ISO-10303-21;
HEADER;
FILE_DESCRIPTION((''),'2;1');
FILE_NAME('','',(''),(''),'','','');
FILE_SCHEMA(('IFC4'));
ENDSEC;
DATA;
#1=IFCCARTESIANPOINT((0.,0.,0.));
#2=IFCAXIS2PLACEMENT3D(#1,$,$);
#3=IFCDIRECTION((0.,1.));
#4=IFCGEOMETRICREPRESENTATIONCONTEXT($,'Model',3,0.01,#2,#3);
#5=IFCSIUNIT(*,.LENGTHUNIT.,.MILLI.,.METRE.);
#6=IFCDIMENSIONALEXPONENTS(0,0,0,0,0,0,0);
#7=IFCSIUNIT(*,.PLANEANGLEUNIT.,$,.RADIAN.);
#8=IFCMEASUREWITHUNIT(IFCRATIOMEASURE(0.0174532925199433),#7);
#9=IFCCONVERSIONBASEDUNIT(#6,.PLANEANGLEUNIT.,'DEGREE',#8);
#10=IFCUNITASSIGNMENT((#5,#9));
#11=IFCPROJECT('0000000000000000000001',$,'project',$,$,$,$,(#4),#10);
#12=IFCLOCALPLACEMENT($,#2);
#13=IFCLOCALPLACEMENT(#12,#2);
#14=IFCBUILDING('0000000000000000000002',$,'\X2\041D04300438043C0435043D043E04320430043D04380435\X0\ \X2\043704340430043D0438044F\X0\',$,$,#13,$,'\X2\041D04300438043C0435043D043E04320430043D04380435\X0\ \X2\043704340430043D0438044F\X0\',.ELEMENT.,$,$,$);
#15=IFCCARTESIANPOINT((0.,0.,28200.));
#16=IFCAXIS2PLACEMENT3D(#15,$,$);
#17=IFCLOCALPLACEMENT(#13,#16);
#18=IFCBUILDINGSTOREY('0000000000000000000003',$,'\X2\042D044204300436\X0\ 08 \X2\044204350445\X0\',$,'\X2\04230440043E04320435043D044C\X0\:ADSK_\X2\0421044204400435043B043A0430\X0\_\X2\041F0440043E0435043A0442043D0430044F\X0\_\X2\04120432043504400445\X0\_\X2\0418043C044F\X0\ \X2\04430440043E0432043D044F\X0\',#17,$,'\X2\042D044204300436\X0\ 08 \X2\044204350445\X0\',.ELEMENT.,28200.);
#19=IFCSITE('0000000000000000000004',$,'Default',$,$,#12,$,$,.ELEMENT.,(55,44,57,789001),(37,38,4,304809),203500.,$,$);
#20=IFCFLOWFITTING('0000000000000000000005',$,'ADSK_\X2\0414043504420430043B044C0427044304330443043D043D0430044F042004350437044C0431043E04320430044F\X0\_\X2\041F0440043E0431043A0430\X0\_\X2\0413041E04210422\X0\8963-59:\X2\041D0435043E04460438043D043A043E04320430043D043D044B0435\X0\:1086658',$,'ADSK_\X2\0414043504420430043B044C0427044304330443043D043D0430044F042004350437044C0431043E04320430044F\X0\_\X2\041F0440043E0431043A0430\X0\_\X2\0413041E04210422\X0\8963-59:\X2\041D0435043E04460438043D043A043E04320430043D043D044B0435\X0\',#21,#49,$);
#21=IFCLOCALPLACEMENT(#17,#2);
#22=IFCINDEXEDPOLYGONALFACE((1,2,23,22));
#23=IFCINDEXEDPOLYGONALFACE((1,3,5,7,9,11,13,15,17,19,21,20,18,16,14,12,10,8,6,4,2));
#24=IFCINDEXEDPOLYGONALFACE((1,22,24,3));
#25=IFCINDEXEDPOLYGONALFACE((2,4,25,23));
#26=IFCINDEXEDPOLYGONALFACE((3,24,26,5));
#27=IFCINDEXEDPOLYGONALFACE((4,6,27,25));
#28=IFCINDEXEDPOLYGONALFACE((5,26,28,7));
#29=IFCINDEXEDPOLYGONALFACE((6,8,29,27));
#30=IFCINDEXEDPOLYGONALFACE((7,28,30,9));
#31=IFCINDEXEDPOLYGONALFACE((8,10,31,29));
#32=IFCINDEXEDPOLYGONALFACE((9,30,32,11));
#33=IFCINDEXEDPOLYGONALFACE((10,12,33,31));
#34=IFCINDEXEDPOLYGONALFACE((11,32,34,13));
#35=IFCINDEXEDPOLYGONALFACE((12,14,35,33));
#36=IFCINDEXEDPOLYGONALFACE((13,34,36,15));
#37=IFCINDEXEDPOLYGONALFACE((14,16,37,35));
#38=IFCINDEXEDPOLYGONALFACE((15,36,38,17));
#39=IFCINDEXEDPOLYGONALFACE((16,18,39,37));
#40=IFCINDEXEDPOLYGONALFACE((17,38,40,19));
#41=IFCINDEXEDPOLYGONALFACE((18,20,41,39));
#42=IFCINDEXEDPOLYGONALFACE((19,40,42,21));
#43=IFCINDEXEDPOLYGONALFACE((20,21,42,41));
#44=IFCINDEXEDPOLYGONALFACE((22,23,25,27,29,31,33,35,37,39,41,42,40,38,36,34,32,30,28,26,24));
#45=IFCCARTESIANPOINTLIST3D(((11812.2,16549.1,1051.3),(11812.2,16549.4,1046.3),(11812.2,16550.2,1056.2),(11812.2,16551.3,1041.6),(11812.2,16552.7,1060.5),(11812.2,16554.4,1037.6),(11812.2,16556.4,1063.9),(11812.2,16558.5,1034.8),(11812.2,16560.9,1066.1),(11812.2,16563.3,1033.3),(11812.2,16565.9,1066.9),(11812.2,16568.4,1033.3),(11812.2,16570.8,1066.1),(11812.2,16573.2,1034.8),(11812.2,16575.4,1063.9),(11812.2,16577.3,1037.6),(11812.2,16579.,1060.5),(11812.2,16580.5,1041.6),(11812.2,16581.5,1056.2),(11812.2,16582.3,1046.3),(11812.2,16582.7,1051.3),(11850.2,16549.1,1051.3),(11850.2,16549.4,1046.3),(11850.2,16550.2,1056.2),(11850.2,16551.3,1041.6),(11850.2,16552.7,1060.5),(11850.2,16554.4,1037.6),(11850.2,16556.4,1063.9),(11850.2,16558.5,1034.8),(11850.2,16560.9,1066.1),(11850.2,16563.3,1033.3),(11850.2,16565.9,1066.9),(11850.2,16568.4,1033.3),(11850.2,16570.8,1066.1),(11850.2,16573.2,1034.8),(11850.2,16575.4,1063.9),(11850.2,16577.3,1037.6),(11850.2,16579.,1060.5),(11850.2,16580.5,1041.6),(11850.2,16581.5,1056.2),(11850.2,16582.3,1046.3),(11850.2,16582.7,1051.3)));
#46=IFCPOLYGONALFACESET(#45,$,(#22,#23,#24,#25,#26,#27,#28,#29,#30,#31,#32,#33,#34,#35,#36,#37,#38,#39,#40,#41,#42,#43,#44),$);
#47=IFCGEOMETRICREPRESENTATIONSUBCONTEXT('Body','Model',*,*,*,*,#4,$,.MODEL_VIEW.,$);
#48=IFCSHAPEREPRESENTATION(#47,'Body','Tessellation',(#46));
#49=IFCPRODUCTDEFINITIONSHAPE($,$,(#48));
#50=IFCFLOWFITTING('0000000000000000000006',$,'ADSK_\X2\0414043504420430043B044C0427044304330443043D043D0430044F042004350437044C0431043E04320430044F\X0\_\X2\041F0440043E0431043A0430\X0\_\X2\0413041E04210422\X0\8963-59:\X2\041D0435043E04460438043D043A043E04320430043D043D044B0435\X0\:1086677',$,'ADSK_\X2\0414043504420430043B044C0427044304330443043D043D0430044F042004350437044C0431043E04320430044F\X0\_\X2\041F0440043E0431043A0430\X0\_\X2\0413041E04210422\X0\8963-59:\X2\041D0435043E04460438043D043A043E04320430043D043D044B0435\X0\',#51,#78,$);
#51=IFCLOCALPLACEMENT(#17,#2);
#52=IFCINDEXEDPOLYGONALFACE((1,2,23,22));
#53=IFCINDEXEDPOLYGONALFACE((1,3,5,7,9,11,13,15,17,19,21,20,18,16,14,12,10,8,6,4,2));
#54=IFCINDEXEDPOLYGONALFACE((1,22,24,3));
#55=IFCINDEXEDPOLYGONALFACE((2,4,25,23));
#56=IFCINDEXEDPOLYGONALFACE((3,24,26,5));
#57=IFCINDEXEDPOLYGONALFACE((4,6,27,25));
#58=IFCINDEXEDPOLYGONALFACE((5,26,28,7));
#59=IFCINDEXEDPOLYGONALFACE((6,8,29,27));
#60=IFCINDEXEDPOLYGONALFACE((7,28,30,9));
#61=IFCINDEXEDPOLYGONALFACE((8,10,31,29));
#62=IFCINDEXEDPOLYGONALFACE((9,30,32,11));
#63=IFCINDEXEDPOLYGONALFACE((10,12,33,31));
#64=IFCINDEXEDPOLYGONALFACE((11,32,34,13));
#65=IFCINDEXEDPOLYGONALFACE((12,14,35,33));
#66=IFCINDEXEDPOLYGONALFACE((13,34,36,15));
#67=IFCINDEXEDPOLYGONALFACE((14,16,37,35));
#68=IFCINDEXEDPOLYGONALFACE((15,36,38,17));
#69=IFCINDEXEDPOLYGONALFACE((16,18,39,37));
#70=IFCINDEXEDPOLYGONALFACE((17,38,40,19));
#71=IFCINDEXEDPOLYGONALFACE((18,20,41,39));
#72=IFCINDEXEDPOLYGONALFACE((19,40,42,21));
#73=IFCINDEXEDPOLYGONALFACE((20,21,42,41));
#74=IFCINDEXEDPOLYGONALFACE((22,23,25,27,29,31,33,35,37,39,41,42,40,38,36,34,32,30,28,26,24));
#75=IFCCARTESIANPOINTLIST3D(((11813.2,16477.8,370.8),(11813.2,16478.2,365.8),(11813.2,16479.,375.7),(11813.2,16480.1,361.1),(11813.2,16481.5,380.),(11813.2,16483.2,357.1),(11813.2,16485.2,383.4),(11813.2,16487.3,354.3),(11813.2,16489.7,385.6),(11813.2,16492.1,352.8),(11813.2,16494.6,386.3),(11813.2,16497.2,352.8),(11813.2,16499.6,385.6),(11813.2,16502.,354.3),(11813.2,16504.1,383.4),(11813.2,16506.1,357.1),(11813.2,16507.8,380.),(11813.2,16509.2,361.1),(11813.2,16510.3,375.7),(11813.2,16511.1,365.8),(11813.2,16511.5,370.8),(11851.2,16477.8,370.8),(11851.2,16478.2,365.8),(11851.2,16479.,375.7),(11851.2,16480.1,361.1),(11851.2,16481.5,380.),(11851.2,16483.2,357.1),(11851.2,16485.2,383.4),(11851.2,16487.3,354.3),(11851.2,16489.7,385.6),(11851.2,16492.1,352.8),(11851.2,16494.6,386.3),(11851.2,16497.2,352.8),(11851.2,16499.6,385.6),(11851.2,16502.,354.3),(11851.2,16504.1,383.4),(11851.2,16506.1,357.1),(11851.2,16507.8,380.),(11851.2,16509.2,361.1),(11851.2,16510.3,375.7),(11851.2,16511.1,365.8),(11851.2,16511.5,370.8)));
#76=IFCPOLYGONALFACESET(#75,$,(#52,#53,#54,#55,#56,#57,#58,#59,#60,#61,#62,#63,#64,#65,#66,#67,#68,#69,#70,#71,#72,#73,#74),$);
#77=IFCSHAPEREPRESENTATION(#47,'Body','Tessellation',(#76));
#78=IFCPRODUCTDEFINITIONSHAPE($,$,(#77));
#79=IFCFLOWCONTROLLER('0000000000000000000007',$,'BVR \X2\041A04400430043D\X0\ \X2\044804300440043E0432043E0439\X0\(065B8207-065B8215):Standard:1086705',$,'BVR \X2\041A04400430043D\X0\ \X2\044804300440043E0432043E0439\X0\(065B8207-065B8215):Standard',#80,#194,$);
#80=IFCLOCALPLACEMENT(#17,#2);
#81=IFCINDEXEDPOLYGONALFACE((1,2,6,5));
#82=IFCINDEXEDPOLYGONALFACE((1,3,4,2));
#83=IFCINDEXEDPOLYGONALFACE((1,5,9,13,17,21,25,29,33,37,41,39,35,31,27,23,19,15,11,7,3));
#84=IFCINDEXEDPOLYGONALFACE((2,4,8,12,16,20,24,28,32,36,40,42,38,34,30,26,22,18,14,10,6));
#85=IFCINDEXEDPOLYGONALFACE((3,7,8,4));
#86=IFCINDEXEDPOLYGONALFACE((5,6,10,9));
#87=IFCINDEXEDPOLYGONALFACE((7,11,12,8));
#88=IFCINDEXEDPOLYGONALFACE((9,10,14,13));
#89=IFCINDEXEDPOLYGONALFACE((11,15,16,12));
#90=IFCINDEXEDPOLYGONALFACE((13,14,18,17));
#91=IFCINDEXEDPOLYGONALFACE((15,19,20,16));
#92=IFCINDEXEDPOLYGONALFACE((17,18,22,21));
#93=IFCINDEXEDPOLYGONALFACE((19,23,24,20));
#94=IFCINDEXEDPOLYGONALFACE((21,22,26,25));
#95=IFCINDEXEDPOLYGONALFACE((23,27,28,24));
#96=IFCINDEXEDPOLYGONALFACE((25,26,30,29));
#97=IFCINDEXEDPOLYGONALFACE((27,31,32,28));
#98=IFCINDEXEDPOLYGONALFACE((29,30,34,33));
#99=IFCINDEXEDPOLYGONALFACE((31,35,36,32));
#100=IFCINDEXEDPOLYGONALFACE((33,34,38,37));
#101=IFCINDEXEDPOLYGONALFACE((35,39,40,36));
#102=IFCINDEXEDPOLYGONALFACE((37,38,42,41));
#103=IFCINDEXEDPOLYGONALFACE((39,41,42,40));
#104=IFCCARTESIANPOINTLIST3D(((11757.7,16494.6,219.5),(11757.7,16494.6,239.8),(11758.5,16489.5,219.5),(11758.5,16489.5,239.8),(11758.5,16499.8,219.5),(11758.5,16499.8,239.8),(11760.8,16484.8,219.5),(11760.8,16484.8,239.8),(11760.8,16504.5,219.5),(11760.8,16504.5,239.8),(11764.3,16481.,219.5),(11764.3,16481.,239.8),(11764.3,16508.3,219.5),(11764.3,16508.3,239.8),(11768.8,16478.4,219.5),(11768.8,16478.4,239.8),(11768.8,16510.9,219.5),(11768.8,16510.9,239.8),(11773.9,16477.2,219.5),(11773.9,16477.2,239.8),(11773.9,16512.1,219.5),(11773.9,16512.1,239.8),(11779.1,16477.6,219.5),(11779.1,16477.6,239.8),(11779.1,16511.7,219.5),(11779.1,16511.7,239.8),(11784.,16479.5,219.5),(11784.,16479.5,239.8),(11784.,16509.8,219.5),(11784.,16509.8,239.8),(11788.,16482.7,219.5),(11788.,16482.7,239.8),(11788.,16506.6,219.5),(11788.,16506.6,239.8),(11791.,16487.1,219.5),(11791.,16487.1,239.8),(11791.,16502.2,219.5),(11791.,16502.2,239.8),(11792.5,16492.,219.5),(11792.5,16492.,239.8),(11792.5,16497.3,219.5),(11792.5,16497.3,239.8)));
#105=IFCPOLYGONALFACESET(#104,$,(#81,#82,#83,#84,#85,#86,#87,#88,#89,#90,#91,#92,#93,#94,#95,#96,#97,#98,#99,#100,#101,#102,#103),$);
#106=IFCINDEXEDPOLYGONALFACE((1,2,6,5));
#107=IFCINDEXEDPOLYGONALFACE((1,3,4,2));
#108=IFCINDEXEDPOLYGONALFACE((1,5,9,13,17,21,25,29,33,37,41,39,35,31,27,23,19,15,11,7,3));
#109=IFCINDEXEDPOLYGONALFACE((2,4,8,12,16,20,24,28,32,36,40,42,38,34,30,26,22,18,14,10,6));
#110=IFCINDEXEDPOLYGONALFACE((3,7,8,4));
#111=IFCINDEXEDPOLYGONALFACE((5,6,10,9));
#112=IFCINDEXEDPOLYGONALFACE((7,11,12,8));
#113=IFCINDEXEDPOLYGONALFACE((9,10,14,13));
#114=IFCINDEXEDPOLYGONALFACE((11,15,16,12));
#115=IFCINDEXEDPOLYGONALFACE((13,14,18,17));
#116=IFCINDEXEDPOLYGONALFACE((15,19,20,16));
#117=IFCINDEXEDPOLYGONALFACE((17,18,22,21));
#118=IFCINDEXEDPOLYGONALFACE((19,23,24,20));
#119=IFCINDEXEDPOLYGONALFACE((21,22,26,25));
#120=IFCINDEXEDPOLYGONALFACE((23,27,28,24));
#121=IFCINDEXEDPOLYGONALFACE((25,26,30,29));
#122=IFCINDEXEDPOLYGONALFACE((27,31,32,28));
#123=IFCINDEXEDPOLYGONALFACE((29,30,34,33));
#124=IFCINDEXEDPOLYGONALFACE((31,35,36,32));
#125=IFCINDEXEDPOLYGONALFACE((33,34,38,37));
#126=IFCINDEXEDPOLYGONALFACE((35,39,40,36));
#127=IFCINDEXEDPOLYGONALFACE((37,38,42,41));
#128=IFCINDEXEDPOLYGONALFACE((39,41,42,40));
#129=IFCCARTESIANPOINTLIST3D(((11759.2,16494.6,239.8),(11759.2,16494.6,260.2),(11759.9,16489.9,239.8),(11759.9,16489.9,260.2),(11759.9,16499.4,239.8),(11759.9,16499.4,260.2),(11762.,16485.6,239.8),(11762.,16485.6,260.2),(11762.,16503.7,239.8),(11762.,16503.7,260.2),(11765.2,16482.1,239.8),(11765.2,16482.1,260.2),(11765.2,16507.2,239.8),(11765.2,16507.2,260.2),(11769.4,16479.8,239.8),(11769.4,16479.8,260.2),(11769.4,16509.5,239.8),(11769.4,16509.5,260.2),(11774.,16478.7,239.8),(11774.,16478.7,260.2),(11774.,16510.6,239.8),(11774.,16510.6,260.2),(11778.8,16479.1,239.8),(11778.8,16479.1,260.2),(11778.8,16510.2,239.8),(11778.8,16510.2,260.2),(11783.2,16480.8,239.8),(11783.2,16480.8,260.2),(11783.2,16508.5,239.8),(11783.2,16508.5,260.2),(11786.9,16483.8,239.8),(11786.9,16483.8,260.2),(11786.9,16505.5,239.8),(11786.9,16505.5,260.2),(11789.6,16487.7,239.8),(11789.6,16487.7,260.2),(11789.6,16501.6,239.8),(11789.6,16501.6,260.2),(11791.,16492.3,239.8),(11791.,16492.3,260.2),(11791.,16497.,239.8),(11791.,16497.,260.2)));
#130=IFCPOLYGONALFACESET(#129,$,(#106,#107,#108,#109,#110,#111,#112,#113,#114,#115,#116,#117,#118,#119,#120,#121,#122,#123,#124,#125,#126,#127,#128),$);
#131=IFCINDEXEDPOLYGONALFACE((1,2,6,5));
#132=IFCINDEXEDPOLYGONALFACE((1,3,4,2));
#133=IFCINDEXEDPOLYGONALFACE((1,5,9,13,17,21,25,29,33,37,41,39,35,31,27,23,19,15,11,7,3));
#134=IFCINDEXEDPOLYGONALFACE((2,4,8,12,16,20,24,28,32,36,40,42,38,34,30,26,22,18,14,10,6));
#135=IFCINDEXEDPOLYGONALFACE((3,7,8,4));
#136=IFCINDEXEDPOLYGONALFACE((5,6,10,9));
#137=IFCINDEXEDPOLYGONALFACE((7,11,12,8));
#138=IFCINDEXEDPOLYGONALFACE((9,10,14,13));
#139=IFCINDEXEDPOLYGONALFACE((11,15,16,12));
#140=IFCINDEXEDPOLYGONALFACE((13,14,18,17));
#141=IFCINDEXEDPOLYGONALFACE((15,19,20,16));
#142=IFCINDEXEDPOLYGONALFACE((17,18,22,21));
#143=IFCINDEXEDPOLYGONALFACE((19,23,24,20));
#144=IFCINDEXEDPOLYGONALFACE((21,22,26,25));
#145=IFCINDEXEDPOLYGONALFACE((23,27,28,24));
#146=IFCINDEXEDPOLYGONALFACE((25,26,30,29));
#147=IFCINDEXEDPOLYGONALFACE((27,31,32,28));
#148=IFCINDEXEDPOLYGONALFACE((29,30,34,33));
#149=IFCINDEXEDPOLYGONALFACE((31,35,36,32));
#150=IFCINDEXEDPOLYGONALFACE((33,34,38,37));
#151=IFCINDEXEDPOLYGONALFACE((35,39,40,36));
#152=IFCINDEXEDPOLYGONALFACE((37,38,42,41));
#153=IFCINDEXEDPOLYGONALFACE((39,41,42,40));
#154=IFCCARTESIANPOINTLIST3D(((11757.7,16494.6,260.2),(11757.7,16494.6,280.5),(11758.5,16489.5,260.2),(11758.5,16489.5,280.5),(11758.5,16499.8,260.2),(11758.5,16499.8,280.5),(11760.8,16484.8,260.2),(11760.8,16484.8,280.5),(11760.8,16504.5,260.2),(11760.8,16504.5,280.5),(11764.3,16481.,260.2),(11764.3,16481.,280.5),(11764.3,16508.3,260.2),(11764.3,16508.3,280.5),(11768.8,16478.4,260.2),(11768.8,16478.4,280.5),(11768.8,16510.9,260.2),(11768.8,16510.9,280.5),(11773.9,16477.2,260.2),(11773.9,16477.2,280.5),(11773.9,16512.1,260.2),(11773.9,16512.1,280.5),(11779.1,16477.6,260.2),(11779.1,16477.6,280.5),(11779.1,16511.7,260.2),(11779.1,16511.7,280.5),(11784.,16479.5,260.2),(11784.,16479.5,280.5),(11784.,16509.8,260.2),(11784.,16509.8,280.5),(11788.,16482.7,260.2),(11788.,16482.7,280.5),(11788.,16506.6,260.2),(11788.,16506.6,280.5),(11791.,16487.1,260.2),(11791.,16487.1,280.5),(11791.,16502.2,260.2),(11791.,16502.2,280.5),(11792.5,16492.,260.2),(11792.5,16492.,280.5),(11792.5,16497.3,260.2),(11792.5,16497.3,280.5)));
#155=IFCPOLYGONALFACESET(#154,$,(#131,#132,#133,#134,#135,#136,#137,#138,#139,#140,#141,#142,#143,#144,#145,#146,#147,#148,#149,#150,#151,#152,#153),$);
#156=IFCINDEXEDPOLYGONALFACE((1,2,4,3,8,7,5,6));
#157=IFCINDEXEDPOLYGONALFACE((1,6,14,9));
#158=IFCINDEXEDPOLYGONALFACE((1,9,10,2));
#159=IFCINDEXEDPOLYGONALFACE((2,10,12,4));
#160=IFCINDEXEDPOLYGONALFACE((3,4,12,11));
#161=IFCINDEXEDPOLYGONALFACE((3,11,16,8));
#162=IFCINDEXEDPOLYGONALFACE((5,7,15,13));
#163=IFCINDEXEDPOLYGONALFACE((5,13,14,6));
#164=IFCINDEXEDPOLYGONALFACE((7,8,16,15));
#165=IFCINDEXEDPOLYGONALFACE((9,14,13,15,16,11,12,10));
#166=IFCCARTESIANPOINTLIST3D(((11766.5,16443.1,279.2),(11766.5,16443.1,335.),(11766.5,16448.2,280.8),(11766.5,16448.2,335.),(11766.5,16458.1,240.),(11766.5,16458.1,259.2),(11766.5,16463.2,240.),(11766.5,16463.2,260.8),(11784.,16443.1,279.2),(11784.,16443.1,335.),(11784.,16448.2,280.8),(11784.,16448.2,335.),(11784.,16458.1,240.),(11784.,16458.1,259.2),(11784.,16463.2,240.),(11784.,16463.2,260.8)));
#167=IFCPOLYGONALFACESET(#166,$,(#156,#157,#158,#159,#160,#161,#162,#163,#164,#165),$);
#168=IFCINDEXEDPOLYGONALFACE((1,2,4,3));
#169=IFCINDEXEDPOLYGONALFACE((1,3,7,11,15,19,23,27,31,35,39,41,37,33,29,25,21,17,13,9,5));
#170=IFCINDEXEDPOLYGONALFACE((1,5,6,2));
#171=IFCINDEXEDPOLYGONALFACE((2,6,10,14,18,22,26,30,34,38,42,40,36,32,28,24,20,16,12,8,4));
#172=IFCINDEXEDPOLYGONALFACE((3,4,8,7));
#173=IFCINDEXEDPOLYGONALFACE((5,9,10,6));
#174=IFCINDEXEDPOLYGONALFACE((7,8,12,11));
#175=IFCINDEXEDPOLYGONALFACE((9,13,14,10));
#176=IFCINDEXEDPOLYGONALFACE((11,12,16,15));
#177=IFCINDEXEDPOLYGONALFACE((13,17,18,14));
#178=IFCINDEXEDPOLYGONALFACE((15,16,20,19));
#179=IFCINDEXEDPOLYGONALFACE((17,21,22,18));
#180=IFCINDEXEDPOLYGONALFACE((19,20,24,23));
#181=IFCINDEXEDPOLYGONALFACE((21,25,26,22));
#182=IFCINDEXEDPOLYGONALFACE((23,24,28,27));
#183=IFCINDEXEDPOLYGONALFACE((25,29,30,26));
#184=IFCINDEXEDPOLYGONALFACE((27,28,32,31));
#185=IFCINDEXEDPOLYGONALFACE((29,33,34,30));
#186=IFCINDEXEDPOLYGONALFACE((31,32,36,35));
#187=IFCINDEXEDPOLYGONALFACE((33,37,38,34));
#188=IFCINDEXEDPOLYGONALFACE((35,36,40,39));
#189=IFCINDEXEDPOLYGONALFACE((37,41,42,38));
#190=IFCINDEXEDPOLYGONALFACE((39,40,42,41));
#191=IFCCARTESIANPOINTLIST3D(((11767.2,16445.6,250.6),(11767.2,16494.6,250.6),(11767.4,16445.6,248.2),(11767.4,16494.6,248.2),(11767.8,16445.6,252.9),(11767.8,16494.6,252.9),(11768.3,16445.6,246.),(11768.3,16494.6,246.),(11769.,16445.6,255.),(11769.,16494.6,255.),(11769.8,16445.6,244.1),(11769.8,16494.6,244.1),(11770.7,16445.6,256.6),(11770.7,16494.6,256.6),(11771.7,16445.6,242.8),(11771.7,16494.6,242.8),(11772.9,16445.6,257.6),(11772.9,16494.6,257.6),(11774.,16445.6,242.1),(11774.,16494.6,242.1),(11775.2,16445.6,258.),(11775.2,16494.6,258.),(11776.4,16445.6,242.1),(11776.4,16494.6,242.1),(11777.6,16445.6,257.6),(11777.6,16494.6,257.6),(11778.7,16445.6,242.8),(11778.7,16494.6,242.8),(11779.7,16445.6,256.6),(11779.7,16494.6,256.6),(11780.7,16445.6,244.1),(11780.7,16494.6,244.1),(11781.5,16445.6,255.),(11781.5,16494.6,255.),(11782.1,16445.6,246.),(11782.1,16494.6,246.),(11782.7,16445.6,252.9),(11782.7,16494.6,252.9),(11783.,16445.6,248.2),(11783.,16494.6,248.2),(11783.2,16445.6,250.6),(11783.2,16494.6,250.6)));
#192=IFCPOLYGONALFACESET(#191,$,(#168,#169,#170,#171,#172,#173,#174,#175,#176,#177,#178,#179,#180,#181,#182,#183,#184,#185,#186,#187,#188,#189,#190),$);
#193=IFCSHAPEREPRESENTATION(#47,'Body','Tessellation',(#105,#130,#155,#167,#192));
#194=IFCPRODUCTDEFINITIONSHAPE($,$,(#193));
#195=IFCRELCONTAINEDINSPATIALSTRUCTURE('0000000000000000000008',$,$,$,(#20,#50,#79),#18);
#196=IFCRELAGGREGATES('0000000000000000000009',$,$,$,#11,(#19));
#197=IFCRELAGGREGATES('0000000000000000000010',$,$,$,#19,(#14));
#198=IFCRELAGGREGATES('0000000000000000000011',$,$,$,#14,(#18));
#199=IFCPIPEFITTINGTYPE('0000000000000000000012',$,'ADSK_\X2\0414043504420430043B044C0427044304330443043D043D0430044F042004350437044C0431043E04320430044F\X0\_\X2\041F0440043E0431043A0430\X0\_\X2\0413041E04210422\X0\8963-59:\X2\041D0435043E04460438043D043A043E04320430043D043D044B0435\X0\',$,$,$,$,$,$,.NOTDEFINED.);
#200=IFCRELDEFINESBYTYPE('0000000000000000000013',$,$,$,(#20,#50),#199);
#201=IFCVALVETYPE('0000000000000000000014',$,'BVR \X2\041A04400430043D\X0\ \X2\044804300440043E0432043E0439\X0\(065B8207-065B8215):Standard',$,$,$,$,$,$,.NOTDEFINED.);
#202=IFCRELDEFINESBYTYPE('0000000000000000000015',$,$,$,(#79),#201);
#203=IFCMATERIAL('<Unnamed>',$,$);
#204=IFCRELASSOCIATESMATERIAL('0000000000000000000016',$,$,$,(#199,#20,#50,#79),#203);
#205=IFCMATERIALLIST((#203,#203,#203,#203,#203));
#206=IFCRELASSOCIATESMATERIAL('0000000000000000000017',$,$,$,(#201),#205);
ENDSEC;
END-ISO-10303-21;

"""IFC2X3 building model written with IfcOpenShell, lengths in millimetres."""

from ifc_helpers import new_model, entity, si_unit, converted_unit, direction, frame, origin, origin_2d_with_axis, place, context, subcontext, project, spatial, polyline, circle, outline, extrude, source, transform, mapped, material, material_list, type_object, type_shapes, element, save


model = new_model("IFC2X3")

# Units and contexts
model_context = context("Model", 3, precision=0.01, world=origin(), true_north=direction((0.0, 1.0)))
body_context = subcontext(model_context, "Body", "Model", "MODEL_VIEW")
ifc_project = project(units=[si_unit("LENGTHUNIT", "METRE", prefix="MILLI"), converted_unit("PLANEANGLEUNIT", "DEGREE", entity("IfcRatioMeasure", 0.0174532925199433), si_unit("PLANEANGLEUNIT", "RADIAN"), dimensions=[0, 0, 0, 0, 0, 0, 0])], contexts=[model_context])

# Site, building, storey
site_placement = place(None, origin())
site = spatial("IfcSite", under=ifc_project, at=site_placement, Name="Default", CompositionType="ELEMENT", RefLatitude=(55, 44, 57, 789001), RefLongitude=(37, 38, 4, 304809), RefElevation=203500.0)
building_placement = place(site_placement, origin())
building = spatial("IfcBuilding", under=site, at=building_placement, Name="Наименование здания", LongName="Наименование здания", CompositionType="ELEMENT")
storey_placement = place(building_placement, frame((0.0, 0.0, 28200.0)))
storey = spatial("IfcBuildingStorey", under=building, at=storey_placement, Name="Этаж 08 тех", ObjectType="Уровень:ADSK_Стрелка_Проектная_Вверх_Имя уровня", LongName="Этаж 08 тех", CompositionType="ELEMENT", Elevation=28200.0)

# Flow fittings
ifc_material = material(Name="<Unnamed>")
pipe_fitting_type_1 = type_object("IfcPipeFittingType", Name="ADSK_ДетальЧугуннаяРезьбовая_Пробка_ГОСТ8963-59:Неоцинкованные", PredefinedType="NOTDEFINED", material=ifc_material)
shared_shape_1 = source(origin(), body_context, "Body", "SweptSolid", [
    extrude(circle(Radius=16.9, at=origin_2d_with_axis()), frame((0.0, 0.0, 0.0), z_axis=(1.0, 0.0, 0.0), x_axis=(0.0, 1.0, 0.0)), (0.0, 0.0, 1.0), 38.0),
])
type_shapes(pipe_fitting_type_1, [shared_shape_1])
for number, where, z_axis, x_axis, name in (
    (1, (11812.2, 16565.9, 1050.0), (0.0, -1.0, 0.0), (1.0, 0.0, 0.0), "ADSK_ДетальЧугуннаяРезьбовая_Пробка_ГОСТ8963-59:Неоцинкованные:1086658"),
    (2, (11813.2, 16494.7, 369.5), (0.0, -1.0, 0.0), (1.0, 0.0, 0.0), "ADSK_ДетальЧугуннаяРезьбовая_Пробка_ГОСТ8963-59:Неоцинкованные:1086677"),
):
    element("IfcFlowFitting", number, at=place(storey_placement, frame(where, z_axis=z_axis, x_axis=x_axis)), inside=storey, type_object=pipe_fitting_type_1, material=ifc_material, Name=name, ObjectType="ADSK_ДетальЧугуннаяРезьбовая_Пробка_ГОСТ8963-59:Неоцинкованные", context=body_context, shape_type="MappedRepresentation", body=[
        mapped(shared_shape_1, transform((0.0, 0.0, 0.0), scale=1.0)),
    ])

# Flow controller
ifc_material_list = material_list([ifc_material, ifc_material, ifc_material, ifc_material, ifc_material])
valve_type = type_object("IfcValveType", Name="BVR Кран шаровой(065B8207-065B8215):Standard", PredefinedType="NOTDEFINED", material=ifc_material_list)
shared_shape_2 = source(origin(), body_context, "Body", "SweptSolid", [
    extrude(circle(Radius=17.5, at=origin_2d_with_axis()), frame((-30.5, 0.0, 0.0), z_axis=(1.0, 0.0, 0.0), x_axis=(0.0, 1.0, 0.0)), (0.0, 0.0, 1.0), 20.3),
    extrude(circle(Radius=16.0, at=origin_2d_with_axis()), frame((-10.2, 0.0, 0.0), z_axis=(1.0, 0.0, 0.0), x_axis=(0.0, 1.0, 0.0)), (0.0, 0.0, 1.0), 20.3),
    extrude(circle(Radius=17.5, at=origin_2d_with_axis()), frame((10.2, 0.0, 0.0), z_axis=(1.0, 0.0, 0.0), x_axis=(0.0, 1.0, 0.0)), (0.0, 0.0, 1.0), 20.3),
    extrude(outline(polyline([(-38.8, -5.0), (-38.8, -10.0), (-17.9, -10.0), (2.1, 5.0), (56.2, 5.0), (56.2, 10.0), (0.4, 10.0), (-19.6, -5.0), (-38.8, -5.0)])), frame((28.8, -8.8, 41.5), z_axis=(0.0, -1.0, 0.0), x_axis=(1.0, 0.0, 0.0)), (0.0, 0.0, -1.0), 17.5),
    extrude(circle(Radius=8.0, at=origin_2d_with_axis()), origin(), (0.0, 0.0, 1.0), 49.0),
])
type_shapes(valve_type, [shared_shape_2])
flow_controller_placement = place(storey_placement, frame((11775.2, 16494.7, 250.0), z_axis=(0.0, -1.0, 0.0), x_axis=(0.0, 0.0, 1.0)))
element("IfcFlowController", 3, at=flow_controller_placement, inside=storey, type_object=valve_type, material=ifc_material, Name="BVR Кран шаровой(065B8207-065B8215):Standard:1086705", ObjectType="BVR Кран шаровой(065B8207-065B8215):Standard", context=body_context, shape_type="MappedRepresentation", body=[
    mapped(shared_shape_2, transform((0.0, 0.0, 0.0), scale=1.0)),
])

save(model, "model.ifc")
